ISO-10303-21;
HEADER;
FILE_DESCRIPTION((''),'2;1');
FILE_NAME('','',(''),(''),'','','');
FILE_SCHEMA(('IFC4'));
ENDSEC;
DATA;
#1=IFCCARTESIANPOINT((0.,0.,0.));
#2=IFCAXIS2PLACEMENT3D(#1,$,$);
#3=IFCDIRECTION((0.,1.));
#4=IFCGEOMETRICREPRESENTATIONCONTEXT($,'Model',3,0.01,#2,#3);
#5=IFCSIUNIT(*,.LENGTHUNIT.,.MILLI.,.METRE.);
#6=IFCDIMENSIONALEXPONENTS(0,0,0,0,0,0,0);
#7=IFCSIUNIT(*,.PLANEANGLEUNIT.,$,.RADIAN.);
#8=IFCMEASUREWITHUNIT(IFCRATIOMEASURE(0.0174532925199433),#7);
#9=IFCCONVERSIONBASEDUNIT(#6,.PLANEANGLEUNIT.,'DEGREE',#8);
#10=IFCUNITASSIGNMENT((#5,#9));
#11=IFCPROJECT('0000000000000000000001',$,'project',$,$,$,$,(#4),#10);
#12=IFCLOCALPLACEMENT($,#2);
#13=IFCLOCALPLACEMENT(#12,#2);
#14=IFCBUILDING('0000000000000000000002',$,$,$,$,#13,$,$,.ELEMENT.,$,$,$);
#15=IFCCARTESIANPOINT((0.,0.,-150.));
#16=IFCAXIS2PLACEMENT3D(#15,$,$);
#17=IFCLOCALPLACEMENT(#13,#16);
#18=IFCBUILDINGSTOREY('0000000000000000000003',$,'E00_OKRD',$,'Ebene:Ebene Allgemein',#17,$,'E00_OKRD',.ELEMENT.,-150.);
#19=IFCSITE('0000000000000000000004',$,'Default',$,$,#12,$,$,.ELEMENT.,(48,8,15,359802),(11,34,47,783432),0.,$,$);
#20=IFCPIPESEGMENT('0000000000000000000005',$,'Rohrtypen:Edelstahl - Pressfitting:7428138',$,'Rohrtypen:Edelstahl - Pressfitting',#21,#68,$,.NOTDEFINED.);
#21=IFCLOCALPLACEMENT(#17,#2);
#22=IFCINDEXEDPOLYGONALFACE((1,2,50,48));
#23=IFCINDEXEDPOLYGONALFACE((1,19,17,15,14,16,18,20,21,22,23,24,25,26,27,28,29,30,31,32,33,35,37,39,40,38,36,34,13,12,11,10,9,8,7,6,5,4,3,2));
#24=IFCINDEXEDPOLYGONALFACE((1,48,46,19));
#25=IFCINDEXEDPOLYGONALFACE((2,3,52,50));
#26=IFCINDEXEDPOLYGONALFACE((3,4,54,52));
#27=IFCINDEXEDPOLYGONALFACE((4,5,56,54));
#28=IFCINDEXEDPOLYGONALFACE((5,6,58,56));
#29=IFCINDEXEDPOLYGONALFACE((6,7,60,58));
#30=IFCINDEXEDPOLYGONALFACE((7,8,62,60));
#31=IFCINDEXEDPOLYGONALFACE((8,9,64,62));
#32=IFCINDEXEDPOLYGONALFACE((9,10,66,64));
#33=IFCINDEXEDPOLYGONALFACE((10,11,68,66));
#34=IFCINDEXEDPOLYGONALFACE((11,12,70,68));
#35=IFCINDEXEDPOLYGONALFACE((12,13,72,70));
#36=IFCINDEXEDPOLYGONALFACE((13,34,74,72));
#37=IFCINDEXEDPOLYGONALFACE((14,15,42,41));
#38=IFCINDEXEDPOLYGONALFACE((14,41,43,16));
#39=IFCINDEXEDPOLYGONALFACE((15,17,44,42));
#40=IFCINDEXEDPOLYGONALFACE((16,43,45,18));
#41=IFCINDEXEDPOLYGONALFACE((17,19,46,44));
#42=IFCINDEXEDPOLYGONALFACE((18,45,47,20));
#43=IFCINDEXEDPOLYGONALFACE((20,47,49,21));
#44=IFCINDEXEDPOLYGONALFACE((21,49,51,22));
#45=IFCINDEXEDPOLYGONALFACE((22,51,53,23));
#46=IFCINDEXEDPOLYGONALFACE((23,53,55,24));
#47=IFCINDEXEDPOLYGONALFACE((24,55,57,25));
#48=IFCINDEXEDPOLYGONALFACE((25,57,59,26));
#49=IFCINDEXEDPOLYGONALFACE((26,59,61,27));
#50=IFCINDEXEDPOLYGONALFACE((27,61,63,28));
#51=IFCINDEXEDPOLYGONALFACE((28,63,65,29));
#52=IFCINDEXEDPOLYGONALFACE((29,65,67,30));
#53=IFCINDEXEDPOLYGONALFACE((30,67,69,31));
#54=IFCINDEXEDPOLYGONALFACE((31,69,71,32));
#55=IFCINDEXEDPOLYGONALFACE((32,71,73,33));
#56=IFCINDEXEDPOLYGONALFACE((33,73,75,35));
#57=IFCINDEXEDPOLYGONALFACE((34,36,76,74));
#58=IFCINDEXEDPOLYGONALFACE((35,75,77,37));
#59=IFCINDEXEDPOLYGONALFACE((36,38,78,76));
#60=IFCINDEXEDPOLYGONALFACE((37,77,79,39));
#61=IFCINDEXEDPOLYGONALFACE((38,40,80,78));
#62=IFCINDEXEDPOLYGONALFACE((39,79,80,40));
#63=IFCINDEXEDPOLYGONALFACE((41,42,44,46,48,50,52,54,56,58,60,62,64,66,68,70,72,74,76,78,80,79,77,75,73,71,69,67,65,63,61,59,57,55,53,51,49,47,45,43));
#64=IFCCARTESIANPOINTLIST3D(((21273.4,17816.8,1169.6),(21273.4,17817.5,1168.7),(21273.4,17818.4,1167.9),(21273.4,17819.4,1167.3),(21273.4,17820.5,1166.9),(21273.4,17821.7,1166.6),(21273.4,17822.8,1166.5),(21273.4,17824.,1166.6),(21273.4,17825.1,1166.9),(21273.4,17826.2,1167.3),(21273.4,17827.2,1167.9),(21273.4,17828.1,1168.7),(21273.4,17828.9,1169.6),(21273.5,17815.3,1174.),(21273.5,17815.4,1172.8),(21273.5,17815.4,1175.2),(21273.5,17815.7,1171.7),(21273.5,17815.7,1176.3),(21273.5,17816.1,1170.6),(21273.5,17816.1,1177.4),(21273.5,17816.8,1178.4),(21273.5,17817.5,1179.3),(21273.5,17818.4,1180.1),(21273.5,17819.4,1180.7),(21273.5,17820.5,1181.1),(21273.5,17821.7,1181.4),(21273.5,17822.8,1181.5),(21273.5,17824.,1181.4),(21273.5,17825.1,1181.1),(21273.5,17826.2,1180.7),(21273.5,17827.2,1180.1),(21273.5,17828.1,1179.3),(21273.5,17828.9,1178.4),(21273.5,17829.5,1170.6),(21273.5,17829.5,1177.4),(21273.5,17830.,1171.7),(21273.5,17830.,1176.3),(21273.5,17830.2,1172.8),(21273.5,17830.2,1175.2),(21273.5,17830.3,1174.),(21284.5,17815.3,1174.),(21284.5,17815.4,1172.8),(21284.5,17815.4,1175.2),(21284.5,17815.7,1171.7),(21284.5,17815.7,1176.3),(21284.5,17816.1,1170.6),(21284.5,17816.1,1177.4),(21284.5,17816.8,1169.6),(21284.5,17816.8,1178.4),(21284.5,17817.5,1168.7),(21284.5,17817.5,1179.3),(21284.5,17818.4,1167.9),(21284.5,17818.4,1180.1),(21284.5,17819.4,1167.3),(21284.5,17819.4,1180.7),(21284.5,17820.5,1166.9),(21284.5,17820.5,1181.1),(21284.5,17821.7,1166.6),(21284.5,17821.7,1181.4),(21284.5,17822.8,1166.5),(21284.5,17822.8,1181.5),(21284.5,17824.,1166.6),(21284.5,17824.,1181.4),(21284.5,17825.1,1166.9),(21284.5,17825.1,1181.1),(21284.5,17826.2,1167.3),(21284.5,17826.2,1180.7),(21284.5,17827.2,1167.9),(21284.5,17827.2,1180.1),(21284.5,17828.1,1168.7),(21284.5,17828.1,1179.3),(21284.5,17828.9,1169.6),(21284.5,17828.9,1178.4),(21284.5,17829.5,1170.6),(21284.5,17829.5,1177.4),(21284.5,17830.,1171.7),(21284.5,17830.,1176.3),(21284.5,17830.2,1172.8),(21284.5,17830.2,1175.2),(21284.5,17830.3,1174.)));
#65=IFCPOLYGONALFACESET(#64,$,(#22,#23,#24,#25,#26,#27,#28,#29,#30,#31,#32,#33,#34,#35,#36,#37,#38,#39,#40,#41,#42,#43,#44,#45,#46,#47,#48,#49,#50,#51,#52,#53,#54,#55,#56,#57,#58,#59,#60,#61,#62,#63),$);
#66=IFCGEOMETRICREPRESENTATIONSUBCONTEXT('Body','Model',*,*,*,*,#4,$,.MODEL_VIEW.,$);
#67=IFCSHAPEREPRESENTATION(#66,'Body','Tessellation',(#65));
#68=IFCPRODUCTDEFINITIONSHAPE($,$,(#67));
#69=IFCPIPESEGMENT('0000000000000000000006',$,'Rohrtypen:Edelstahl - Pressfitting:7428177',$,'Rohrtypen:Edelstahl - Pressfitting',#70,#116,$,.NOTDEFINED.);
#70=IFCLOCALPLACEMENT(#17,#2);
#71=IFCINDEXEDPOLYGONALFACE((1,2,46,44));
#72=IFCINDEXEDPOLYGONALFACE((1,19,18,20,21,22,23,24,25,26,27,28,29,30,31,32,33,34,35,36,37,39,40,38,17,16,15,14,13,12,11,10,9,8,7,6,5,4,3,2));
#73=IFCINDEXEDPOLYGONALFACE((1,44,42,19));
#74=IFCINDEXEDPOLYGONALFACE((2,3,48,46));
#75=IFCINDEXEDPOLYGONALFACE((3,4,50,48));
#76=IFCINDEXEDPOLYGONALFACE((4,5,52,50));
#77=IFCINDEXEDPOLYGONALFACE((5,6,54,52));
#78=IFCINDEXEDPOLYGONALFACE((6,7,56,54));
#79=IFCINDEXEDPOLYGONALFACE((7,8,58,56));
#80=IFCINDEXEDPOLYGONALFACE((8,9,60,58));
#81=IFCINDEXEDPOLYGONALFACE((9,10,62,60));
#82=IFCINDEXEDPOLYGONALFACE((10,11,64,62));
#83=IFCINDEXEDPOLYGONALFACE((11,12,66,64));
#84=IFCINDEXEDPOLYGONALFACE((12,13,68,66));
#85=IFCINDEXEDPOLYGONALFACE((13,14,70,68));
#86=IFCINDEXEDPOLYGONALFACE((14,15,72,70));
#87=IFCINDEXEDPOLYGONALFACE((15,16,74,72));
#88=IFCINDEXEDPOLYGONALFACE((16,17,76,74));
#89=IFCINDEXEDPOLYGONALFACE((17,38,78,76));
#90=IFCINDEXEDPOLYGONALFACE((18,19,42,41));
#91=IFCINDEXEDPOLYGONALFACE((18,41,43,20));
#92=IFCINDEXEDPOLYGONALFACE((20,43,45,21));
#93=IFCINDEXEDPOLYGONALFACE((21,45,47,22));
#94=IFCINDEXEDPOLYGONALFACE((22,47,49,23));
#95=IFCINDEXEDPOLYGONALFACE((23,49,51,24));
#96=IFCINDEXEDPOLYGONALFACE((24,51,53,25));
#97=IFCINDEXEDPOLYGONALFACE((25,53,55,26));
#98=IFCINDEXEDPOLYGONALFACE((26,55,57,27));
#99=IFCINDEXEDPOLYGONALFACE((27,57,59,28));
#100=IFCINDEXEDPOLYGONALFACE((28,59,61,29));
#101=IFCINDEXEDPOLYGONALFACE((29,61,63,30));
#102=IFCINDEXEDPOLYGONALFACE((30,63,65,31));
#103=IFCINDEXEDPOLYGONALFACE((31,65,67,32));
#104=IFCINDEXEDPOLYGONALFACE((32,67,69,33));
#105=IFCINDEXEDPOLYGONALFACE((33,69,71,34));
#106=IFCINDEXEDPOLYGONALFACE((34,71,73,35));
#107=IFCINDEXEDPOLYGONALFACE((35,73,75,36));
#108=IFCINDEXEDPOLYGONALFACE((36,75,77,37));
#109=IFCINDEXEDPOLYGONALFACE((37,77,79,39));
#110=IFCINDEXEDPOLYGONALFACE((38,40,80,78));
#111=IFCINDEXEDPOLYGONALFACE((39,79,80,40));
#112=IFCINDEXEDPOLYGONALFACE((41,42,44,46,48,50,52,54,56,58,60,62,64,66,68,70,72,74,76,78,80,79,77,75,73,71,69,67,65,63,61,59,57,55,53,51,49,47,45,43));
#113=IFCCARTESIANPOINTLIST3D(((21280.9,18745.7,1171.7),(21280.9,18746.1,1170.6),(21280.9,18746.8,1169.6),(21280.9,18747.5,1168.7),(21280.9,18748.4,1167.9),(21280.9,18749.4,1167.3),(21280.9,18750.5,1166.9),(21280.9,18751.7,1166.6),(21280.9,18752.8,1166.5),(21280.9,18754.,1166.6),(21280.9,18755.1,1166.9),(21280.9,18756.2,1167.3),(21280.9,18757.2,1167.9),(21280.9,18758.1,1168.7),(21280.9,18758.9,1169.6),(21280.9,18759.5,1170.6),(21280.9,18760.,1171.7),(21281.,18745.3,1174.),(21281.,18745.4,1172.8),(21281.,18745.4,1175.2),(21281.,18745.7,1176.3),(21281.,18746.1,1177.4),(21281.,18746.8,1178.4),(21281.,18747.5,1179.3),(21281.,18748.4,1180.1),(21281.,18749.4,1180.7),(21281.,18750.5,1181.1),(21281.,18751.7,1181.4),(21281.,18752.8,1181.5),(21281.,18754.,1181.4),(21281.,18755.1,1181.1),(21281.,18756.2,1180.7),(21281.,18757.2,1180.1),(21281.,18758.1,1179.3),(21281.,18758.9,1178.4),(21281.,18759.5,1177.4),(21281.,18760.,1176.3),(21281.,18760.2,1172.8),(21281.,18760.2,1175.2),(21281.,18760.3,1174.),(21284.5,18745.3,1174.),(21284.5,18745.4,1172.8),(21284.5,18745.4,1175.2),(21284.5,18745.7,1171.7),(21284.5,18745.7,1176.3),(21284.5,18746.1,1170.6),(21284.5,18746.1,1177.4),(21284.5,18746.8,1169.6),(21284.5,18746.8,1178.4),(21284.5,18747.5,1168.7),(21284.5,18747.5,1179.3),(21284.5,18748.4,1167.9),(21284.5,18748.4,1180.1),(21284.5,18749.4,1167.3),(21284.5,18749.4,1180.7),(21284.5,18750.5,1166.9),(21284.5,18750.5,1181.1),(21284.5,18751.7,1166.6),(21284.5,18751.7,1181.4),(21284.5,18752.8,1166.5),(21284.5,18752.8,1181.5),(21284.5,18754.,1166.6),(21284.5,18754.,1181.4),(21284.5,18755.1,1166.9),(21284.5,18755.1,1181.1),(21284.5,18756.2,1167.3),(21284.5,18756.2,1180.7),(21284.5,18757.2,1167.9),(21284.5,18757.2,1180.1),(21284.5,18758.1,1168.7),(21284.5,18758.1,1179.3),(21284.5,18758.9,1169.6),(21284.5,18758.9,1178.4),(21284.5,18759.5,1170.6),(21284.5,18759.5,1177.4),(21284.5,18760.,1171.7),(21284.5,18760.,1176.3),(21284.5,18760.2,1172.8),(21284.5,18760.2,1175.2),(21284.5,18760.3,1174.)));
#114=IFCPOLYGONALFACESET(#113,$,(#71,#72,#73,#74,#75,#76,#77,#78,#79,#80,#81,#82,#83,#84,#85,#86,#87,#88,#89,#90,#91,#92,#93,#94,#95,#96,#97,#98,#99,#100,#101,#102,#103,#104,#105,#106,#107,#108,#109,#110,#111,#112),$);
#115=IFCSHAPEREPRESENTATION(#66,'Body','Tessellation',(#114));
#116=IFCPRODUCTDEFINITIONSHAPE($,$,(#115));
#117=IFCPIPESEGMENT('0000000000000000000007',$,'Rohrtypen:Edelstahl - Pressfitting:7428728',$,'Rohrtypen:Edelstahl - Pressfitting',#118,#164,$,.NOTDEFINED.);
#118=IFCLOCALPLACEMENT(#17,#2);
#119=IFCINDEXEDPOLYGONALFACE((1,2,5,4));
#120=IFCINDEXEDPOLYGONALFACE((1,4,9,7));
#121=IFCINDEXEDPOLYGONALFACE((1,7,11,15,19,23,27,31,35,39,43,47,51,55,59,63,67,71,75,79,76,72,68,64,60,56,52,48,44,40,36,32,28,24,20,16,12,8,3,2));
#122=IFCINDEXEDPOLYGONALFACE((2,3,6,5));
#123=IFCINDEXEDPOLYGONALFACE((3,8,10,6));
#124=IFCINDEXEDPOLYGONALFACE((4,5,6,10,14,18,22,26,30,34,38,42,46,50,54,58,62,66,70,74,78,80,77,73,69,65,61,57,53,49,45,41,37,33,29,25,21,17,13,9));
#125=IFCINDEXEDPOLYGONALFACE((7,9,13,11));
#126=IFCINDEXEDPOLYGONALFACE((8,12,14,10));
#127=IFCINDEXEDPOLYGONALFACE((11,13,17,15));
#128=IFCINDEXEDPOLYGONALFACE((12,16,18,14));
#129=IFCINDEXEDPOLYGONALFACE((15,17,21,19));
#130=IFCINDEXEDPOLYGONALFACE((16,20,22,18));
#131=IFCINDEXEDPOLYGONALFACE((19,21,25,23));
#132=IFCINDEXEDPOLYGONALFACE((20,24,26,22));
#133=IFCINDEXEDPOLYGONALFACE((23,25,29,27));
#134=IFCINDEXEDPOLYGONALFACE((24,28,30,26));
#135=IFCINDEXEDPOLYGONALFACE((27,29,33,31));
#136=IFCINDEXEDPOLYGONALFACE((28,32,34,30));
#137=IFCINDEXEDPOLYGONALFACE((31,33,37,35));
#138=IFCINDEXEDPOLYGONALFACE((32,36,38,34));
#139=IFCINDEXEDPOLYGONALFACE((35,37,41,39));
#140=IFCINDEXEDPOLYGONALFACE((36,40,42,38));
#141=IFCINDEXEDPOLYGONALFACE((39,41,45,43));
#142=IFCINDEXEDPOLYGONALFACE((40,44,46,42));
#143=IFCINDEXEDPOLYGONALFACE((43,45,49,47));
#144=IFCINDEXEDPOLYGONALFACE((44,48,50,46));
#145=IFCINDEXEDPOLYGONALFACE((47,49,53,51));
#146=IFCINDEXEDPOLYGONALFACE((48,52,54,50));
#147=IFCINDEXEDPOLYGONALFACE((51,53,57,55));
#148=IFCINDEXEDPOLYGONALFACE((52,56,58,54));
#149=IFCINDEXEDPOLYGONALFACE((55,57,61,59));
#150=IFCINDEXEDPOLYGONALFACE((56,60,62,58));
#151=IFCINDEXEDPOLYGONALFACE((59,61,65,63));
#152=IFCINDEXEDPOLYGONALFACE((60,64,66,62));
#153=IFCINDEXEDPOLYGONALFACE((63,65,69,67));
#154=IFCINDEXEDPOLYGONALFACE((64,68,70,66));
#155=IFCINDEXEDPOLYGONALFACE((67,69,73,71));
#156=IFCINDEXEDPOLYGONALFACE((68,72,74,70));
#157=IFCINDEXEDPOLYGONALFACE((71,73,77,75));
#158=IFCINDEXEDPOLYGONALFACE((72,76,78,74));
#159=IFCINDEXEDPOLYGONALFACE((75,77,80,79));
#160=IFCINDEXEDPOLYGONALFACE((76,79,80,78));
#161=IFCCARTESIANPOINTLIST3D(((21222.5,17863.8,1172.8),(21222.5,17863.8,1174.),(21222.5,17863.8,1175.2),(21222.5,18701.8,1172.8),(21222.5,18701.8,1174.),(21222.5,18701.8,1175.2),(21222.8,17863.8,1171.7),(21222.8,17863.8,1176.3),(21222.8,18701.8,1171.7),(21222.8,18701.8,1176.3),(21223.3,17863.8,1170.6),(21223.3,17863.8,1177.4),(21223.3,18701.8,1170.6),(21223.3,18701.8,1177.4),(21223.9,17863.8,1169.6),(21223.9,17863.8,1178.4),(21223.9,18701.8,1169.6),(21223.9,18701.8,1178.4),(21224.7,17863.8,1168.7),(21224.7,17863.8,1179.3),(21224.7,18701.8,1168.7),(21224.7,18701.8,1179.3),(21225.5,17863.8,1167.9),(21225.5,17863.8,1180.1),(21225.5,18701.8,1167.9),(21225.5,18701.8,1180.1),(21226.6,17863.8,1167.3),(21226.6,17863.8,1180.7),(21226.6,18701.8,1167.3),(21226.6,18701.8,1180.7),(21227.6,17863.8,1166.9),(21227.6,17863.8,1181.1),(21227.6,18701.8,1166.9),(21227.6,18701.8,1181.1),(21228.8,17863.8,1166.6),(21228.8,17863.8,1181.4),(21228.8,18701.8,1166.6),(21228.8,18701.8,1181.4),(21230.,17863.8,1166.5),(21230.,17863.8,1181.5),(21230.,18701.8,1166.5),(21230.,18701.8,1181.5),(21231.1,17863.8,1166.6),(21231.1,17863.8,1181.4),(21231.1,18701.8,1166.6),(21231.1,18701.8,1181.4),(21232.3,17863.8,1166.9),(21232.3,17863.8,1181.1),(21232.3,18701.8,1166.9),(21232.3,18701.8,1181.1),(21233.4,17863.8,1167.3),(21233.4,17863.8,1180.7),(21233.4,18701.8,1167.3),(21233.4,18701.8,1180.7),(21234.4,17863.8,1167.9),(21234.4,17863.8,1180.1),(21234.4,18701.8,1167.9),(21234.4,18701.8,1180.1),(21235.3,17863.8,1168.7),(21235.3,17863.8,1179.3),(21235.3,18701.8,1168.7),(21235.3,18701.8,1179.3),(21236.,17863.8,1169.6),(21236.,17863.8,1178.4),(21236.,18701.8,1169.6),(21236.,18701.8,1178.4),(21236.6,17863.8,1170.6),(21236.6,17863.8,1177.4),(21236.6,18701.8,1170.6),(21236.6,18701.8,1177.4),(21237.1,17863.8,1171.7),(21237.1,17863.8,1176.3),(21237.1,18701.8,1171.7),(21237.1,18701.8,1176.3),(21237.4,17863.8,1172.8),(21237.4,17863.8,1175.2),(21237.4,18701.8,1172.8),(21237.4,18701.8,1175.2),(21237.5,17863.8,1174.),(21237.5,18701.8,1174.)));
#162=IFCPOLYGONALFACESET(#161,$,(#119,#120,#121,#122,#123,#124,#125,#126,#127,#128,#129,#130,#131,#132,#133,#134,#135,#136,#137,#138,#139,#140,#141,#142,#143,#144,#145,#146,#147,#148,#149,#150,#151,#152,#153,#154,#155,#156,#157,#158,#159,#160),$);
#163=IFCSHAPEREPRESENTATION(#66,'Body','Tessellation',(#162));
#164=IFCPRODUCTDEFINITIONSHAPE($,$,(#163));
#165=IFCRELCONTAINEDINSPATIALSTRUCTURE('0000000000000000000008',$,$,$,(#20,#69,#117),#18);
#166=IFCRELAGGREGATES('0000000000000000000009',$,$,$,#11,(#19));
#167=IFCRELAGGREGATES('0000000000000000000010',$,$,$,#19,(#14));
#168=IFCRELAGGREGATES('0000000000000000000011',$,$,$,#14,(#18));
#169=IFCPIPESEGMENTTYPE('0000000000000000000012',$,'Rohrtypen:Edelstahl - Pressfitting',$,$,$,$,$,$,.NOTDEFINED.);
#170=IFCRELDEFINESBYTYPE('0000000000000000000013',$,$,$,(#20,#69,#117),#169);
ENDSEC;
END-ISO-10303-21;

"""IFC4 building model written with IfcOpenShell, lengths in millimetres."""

from ifc_helpers import new_model, entity, si_unit, converted_unit, direction, frame, origin, place, context, subcontext, project, spatial, indexed_curve, outline, extrude, type_object, element, save


model = new_model("IFC4")

# Units and contexts
model_context = context("Model", 3, precision=0.01, world=origin(), true_north=direction((0.0, 1.0)))
body_context = subcontext(model_context, "Body", "Model", "MODEL_VIEW")
ifc_project = project(units=[si_unit("LENGTHUNIT", "METRE", prefix="MILLI"), converted_unit("PLANEANGLEUNIT", "DEGREE", entity("IfcRatioMeasure", 0.0174532925199433), si_unit("PLANEANGLEUNIT", "RADIAN"), dimensions=[0, 0, 0, 0, 0, 0, 0])], contexts=[model_context])

# Site, building, storey
site_placement = place(None, origin())
site = spatial("IfcSite", under=ifc_project, at=site_placement, Name="Default", CompositionType="ELEMENT", RefLatitude=(48, 8, 15, 359802), RefLongitude=(11, 34, 47, 783432), RefElevation=0.0)
building_placement = place(site_placement, origin())
building = spatial("IfcBuilding", under=site, at=building_placement, CompositionType="ELEMENT")
storey_placement = place(building_placement, frame((0.0, 0.0, -150.0)))
storey = spatial("IfcBuildingStorey", under=building, at=storey_placement, Name="E00_OKRD", ObjectType="Ebene:Ebene Allgemein", LongName="E00_OKRD", CompositionType="ELEMENT", Elevation=-150.0)

# Pipe segments
pipe_segment_type_1 = type_object("IfcPipeSegmentType", Name="Rohrtypen:Edelstahl - Pressfitting", PredefinedType="NOTDEFINED")
pipe_segment_1_placement = place(storey_placement, origin())
element("IfcPipeSegment", 1, at=pipe_segment_1_placement, inside=storey, type_object=pipe_segment_type_1, Name="Rohrtypen:Edelstahl - Pressfitting:7428138", ObjectType="Rohrtypen:Edelstahl - Pressfitting", PredefinedType="NOTDEFINED", context=body_context, shape_type="SweptSolid", body=[
    extrude(outline(indexed_curve([(7.5, 0.0), (7.4, 1.2), (7.1, 2.3), (6.7, 3.4), (6.1, 4.4), (5.3, 5.3), (4.4, 6.1), (3.4, 6.7), (2.3, 7.1), (1.2, 7.4), (0.0, 7.5), (-1.2, 7.4), (-2.3, 7.1), (-3.4, 6.7), (-4.4, 6.1), (-5.3, 5.3), (-6.1, 4.4), (-6.7, 3.4), (-7.1, 2.3), (-7.4, 1.2), (-7.5, 0.0), (-7.4, -1.2), (-7.1, -2.3), (-6.7, -3.4), (-6.1, -4.4), (-5.3, -5.3), (-4.4, -6.1), (-3.4, -6.7), (-2.3, -7.1), (-1.2, -7.4), (0.0, -7.5), (1.2, -7.4), (2.3, -7.1), (3.4, -6.7), (4.4, -6.1), (5.3, -5.3), (6.1, -4.4), (6.7, -3.4), (7.1, -2.3), (7.4, -1.2), (7.5, 0.0)], self_intersect=False)), frame((21273.5, 17822.8, 1174.0), z_axis=(0.999999, 0.0, -0.001254), x_axis=(0.0, -1.0, 0.0)), (0.0, 0.0, 1.0), 11.1),
])
pipe_segment_2_placement = place(storey_placement, origin())
element("IfcPipeSegment", 2, at=pipe_segment_2_placement, inside=storey, type_object=pipe_segment_type_1, Name="Rohrtypen:Edelstahl - Pressfitting:7428177", ObjectType="Rohrtypen:Edelstahl - Pressfitting", PredefinedType="NOTDEFINED", context=body_context, shape_type="SweptSolid", body=[
    extrude(outline(indexed_curve([(7.5, 0.0), (7.4, 1.2), (7.1, 2.3), (6.7, 3.4), (6.1, 4.4), (5.3, 5.3), (4.4, 6.1), (3.4, 6.7), (2.3, 7.1), (1.2, 7.4), (0.0, 7.5), (-1.2, 7.4), (-2.3, 7.1), (-3.4, 6.7), (-4.4, 6.1), (-5.3, 5.3), (-6.1, 4.4), (-6.7, 3.4), (-7.1, 2.3), (-7.4, 1.2), (-7.5, 0.0), (-7.4, -1.2), (-7.1, -2.3), (-6.7, -3.4), (-6.1, -4.4), (-5.3, -5.3), (-4.4, -6.1), (-3.4, -6.7), (-2.3, -7.1), (-1.2, -7.4), (0.0, -7.5), (1.2, -7.4), (2.3, -7.1), (3.4, -6.7), (4.4, -6.1), (5.3, -5.3), (6.1, -4.4), (6.7, -3.4), (7.1, -2.3), (7.4, -1.2), (7.5, 0.0)], self_intersect=False)), frame((21281.0, 18752.8, 1174.0), z_axis=(0.999992, 0.0, -0.003988), x_axis=(0.0, -1.0, 0.0)), (0.0, 0.0, 1.0), 3.6),
])
pipe_segment_3_placement = place(storey_placement, origin())
element("IfcPipeSegment", 3, at=pipe_segment_3_placement, inside=storey, type_object=pipe_segment_type_1, Name="Rohrtypen:Edelstahl - Pressfitting:7428728", ObjectType="Rohrtypen:Edelstahl - Pressfitting", PredefinedType="NOTDEFINED", context=body_context, shape_type="SweptSolid", body=[
    extrude(outline(indexed_curve([(7.5, 0.0), (7.4, 1.2), (7.1, 2.3), (6.7, 3.4), (6.1, 4.4), (5.3, 5.3), (4.4, 6.1), (3.4, 6.7), (2.3, 7.1), (1.2, 7.4), (0.0, 7.5), (-1.2, 7.4), (-2.3, 7.1), (-3.4, 6.7), (-4.4, 6.1), (-5.3, 5.3), (-6.1, 4.4), (-6.7, 3.4), (-7.1, 2.3), (-7.4, 1.2), (-7.5, 0.0), (-7.4, -1.2), (-7.1, -2.3), (-6.7, -3.4), (-6.1, -4.4), (-5.3, -5.3), (-4.4, -6.1), (-3.4, -6.7), (-2.3, -7.1), (-1.2, -7.4), (0.0, -7.5), (1.2, -7.4), (2.3, -7.1), (3.4, -6.7), (4.4, -6.1), (5.3, -5.3), (6.1, -4.4), (6.7, -3.4), (7.1, -2.3), (7.4, -1.2), (7.5, 0.0)], self_intersect=False)), frame((21230.0, 17863.8, 1174.0), z_axis=(0.0, 1.0, 0.0), x_axis=(1.0, 0.0, 0.0)), (0.0, 0.0, 1.0), 838.0),
])

save(model, "model.ifc")
